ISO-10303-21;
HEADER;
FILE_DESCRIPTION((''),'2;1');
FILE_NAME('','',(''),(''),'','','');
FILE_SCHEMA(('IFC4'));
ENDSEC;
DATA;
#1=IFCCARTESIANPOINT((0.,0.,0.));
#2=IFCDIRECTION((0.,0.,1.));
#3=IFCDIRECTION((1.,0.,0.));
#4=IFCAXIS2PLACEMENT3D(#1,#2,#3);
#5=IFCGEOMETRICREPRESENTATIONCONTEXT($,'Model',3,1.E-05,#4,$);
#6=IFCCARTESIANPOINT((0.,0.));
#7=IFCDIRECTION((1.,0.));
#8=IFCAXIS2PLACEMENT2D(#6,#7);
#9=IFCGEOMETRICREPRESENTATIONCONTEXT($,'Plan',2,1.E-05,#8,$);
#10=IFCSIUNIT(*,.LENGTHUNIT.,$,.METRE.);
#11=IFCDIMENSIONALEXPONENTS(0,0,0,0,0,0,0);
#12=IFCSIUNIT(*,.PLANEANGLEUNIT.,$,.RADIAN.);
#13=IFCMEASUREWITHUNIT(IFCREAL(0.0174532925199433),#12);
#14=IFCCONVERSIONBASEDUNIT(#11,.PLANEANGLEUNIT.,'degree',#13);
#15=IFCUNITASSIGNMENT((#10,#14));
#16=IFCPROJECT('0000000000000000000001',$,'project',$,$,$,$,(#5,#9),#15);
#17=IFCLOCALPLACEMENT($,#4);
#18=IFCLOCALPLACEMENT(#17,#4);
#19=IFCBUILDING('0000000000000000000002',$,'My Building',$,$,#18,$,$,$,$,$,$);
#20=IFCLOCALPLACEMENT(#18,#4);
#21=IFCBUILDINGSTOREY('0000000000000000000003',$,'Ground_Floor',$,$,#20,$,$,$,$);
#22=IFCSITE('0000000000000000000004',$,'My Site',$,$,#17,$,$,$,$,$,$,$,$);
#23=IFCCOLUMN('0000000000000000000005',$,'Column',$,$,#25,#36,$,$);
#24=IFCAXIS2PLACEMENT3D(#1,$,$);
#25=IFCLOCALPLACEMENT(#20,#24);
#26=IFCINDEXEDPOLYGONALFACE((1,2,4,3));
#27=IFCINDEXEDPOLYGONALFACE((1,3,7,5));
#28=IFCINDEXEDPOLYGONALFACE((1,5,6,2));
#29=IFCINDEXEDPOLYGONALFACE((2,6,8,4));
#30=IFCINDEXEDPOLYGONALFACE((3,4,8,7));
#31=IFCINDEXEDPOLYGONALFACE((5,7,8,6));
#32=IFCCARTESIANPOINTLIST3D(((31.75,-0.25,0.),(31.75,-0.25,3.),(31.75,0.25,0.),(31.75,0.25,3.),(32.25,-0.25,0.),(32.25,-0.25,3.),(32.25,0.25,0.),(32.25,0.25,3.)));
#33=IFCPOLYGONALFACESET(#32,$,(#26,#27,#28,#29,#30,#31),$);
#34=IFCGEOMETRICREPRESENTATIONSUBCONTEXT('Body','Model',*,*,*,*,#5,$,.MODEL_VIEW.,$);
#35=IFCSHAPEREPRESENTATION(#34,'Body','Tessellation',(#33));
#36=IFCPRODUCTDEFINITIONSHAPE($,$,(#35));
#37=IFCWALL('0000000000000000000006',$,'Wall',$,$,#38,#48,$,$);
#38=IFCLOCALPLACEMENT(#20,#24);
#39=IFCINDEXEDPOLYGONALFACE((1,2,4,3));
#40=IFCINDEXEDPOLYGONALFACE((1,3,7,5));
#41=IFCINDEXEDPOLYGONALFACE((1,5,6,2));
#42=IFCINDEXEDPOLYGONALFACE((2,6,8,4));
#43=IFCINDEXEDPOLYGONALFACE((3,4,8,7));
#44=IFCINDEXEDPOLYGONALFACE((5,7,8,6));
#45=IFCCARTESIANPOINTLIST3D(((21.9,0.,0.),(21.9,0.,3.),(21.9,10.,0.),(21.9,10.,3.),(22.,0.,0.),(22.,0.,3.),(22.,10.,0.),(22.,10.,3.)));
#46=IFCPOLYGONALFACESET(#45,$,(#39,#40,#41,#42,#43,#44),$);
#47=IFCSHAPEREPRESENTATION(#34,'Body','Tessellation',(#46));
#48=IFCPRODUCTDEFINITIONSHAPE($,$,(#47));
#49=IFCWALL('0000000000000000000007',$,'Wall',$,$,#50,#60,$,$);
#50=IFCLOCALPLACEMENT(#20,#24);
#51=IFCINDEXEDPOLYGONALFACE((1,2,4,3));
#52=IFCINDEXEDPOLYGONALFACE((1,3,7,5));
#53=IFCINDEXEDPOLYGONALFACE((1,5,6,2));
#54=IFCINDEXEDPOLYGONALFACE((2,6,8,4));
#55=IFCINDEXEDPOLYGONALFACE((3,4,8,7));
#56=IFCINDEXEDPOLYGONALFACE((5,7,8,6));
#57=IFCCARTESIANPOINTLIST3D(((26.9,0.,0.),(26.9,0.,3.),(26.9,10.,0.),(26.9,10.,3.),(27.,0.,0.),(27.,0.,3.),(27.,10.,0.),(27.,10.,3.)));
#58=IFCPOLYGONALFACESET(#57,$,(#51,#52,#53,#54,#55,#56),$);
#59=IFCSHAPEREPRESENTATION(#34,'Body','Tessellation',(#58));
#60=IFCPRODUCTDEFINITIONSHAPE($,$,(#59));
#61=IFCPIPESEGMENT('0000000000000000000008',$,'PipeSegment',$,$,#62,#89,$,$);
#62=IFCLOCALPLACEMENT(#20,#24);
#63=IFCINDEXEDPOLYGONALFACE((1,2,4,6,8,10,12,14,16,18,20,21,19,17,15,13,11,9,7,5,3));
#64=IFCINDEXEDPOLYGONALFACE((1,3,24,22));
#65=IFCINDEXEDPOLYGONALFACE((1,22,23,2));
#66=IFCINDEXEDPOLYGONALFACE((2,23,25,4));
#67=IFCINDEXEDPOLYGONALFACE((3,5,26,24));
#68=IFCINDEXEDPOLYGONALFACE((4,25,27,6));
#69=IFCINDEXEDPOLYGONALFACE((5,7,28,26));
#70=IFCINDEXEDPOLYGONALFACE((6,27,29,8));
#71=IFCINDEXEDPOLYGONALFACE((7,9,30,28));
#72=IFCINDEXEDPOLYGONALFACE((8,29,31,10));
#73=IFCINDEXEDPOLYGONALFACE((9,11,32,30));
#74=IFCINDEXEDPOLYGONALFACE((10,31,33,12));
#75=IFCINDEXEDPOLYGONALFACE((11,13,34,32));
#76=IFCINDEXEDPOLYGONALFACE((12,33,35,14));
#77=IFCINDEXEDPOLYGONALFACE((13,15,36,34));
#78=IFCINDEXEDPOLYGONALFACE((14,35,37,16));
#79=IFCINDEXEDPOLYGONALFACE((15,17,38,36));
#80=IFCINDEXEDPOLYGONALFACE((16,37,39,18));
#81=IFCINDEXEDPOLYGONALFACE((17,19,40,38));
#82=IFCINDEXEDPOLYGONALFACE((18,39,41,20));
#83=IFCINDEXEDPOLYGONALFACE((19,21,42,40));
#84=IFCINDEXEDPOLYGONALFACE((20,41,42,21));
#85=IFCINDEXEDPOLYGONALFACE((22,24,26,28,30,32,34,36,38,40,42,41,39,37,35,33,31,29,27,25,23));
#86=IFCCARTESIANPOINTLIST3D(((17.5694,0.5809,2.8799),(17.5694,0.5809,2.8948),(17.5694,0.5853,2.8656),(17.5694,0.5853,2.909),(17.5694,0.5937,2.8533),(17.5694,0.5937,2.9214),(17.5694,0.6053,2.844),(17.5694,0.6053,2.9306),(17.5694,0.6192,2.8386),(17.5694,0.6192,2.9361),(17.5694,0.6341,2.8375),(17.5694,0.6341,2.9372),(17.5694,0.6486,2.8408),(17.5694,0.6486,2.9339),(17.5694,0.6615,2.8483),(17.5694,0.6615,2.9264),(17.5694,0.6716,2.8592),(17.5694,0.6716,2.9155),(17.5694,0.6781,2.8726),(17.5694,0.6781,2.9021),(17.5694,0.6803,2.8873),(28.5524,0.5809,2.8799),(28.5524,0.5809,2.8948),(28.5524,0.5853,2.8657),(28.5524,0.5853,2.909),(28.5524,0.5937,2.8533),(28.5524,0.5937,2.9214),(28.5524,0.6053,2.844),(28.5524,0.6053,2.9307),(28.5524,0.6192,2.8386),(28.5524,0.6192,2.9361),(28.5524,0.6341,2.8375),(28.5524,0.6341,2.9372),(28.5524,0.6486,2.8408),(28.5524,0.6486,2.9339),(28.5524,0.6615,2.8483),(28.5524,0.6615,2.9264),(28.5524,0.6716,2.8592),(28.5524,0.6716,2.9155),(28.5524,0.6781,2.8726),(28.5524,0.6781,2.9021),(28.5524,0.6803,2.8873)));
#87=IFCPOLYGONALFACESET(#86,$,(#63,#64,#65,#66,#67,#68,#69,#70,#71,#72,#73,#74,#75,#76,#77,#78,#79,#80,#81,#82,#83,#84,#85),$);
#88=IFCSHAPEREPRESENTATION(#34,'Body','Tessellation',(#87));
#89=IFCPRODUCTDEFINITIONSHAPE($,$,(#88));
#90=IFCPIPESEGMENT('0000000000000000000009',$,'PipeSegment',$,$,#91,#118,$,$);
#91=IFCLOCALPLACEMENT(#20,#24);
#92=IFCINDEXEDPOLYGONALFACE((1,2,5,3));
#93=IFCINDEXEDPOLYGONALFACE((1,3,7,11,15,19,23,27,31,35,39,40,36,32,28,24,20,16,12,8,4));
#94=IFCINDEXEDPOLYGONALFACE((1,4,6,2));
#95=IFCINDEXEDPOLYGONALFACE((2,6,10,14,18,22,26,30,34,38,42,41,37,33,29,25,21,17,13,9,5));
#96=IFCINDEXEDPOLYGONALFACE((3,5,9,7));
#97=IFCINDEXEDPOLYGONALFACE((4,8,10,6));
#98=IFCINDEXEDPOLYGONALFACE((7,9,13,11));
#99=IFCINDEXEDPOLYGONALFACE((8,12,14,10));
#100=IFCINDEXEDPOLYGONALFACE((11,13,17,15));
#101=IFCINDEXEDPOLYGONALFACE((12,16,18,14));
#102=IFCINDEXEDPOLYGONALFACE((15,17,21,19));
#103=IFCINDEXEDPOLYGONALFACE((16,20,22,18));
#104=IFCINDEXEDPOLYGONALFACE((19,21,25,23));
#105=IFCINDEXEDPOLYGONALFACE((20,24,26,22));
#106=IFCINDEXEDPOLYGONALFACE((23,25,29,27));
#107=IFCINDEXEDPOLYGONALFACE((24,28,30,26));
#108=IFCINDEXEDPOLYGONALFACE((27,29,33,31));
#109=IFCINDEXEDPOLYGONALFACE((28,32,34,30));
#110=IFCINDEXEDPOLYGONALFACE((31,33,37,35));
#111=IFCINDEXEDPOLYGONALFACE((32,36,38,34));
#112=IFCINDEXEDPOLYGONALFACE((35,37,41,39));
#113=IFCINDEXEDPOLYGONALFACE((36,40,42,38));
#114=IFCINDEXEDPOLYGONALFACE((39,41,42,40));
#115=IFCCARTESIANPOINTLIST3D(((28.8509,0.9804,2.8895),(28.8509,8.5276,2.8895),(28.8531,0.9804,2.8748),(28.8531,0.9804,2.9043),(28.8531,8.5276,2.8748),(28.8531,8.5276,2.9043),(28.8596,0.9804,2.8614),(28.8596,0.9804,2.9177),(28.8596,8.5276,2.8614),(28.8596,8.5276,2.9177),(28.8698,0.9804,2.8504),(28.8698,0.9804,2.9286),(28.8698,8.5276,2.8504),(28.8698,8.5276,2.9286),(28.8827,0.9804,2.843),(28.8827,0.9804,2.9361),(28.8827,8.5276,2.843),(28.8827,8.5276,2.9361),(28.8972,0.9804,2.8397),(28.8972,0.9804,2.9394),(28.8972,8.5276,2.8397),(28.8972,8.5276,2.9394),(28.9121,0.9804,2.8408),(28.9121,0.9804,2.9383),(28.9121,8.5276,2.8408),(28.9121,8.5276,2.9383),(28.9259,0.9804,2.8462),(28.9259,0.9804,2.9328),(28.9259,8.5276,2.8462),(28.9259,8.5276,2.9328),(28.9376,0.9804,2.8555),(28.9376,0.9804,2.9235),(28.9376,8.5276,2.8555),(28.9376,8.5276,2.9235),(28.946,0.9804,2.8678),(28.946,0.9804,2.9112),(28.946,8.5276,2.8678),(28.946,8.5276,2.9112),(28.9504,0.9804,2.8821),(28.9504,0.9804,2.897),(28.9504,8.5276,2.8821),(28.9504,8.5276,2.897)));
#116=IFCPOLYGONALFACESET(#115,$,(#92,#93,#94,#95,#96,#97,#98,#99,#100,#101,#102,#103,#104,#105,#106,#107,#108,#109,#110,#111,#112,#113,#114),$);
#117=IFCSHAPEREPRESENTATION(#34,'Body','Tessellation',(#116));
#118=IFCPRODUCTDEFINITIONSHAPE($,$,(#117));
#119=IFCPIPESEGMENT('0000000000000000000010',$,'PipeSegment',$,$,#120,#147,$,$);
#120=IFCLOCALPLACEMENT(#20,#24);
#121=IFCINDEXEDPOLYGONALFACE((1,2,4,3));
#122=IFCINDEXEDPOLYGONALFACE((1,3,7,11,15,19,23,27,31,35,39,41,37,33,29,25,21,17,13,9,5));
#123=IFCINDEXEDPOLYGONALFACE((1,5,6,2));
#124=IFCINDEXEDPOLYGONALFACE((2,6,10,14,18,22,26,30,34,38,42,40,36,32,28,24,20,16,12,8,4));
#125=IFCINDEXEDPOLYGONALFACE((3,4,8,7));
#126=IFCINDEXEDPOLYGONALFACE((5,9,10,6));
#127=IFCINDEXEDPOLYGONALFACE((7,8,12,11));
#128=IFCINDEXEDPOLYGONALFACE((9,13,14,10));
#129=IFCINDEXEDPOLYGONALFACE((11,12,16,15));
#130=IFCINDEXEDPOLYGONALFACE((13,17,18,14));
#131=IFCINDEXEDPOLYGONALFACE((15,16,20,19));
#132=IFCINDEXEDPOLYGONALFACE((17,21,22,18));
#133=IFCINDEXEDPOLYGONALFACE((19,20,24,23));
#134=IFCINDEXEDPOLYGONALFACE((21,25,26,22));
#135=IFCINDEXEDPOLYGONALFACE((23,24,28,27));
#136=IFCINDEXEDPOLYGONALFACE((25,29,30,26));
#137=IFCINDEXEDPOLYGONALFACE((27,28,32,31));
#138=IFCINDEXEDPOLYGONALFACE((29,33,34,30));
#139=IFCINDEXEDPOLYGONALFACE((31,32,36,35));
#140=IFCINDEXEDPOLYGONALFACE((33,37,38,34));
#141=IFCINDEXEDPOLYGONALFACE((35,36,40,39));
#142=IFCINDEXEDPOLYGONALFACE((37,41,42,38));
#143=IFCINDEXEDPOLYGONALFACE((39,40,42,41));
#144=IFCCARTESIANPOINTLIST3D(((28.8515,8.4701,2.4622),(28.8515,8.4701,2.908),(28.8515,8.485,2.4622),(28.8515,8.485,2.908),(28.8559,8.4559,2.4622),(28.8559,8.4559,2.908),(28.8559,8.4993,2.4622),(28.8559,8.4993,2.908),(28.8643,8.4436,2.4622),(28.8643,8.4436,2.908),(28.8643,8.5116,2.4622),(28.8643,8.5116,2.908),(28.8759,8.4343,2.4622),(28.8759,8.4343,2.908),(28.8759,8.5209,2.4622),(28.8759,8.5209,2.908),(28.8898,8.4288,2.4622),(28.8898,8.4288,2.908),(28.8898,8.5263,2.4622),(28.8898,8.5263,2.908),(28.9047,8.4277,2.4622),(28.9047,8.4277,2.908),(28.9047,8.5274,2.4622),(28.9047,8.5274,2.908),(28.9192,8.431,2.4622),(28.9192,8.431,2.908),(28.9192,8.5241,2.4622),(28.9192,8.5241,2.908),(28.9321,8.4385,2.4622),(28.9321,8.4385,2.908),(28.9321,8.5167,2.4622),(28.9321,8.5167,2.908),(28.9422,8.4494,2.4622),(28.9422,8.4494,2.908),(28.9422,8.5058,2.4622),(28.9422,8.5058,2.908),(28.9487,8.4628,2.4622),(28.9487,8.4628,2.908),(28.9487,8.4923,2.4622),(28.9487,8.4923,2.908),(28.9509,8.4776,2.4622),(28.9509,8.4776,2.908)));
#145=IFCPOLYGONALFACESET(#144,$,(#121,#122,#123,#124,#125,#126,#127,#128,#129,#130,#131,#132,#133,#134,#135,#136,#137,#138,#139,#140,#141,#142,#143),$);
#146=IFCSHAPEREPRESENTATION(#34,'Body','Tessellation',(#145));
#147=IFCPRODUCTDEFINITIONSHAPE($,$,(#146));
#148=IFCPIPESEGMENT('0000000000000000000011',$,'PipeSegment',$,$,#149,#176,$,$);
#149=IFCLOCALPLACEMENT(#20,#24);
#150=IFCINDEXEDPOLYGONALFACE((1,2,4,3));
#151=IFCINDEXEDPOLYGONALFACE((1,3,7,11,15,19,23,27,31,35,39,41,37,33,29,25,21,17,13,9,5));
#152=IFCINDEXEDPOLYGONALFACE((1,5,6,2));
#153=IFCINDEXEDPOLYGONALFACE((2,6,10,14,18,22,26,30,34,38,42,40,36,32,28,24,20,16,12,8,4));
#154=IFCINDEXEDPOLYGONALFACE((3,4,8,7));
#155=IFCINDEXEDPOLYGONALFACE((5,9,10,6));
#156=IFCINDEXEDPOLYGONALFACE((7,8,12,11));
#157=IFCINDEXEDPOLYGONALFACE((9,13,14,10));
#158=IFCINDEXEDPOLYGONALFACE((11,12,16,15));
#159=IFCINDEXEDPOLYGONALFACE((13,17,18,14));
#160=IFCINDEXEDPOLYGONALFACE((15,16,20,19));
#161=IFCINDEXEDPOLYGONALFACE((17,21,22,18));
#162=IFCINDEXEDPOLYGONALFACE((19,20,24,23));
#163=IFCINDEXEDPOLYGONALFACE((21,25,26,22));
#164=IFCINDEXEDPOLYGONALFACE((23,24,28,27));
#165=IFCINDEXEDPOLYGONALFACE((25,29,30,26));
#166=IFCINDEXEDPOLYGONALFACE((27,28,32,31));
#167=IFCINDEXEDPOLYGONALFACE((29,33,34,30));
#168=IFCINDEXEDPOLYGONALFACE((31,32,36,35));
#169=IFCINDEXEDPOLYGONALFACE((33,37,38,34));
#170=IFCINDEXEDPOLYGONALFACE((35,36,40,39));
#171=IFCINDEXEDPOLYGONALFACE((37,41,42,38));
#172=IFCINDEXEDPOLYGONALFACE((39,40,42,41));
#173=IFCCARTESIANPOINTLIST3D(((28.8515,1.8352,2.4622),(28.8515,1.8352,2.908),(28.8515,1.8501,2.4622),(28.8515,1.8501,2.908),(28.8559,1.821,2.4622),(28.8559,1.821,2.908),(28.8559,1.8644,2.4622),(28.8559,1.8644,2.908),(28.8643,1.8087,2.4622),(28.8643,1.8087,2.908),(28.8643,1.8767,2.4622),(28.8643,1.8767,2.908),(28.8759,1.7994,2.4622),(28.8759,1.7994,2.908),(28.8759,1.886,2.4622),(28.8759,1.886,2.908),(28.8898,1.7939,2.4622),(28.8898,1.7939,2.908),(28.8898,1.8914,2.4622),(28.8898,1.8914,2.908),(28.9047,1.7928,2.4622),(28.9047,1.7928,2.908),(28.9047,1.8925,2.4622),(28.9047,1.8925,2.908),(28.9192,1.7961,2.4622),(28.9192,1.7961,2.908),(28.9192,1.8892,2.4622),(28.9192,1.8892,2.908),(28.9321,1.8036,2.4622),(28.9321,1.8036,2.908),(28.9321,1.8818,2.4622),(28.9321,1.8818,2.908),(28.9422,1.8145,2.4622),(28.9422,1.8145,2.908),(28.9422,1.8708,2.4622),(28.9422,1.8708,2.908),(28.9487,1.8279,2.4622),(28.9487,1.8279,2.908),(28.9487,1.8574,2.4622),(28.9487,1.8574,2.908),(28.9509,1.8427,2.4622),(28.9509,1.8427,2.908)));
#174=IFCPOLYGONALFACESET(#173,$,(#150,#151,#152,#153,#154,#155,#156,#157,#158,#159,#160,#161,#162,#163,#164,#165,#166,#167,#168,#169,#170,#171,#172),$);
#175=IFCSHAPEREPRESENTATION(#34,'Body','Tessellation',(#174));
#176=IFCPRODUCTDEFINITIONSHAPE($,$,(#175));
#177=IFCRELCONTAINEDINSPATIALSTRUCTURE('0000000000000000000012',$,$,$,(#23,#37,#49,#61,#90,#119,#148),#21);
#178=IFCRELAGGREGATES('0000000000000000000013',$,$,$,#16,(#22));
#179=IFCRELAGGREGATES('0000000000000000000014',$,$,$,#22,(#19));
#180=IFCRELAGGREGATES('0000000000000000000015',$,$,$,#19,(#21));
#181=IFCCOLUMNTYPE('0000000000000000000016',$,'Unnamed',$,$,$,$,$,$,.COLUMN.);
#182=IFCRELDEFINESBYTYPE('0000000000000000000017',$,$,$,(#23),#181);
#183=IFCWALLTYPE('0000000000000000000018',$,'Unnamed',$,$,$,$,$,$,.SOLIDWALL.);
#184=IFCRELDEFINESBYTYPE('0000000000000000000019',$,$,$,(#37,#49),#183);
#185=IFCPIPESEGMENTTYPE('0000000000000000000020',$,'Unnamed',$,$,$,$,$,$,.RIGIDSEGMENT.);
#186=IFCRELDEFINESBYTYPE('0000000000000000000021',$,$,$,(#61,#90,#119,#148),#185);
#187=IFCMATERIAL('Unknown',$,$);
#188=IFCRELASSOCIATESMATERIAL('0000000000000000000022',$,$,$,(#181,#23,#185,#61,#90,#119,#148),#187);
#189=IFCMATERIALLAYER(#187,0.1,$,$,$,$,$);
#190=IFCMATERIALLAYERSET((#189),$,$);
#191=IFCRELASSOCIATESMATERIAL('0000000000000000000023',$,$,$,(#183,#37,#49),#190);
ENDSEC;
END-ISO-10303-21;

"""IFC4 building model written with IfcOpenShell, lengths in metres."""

from ifc_helpers import new_model, entity, si_unit, converted_unit, frame, origin_with_axes, origin_2d_with_axis, place, context, subcontext, project, spatial, line, indexed_curve, rectangle, circle, outline, extrude, material, layer, layer_set, layer_usage, material_profile, profile_set, profile_usage, type_object, element, save


model = new_model("IFC4")

# Units and contexts
model_context = context("Model", 3, precision=1e-05, world=origin_with_axes())
plan_context = context("Plan", 2, precision=1e-05, world=origin_2d_with_axis())
body_context_1 = subcontext(model_context, "Body", "Model", "MODEL_VIEW")
ifc_project = project(units=[si_unit("LENGTHUNIT", "METRE"), converted_unit("PLANEANGLEUNIT", "degree", entity("IfcReal", 0.0174532925199433), si_unit("PLANEANGLEUNIT", "RADIAN"), dimensions=[0, 0, 0, 0, 0, 0, 0])], contexts=[model_context, plan_context])

# Site, building, storey
site_placement = place(None, origin_with_axes())
site = spatial("IfcSite", under=ifc_project, at=site_placement, Name="My Site")
building_placement = place(site_placement, origin_with_axes())
building = spatial("IfcBuilding", under=site, at=building_placement, Name="My Building")
storey_placement = place(building_placement, origin_with_axes())
storey = spatial("IfcBuildingStorey", under=building, at=storey_placement, Name="Ground_Floor")

# Column
ifc_material = material(Name="Unknown")
ifc_material_profile_1 = material_profile(ifc_material, rectangle(XDim=0.5, YDim=0.5))
ifc_profile_set_1 = profile_set([ifc_material_profile_1])
ifc_profile_usage_1 = profile_usage(ifc_profile_set_1, cardinal=5)
column_type = type_object("IfcColumnType", Name="Unnamed", PredefinedType="COLUMN", material=ifc_profile_set_1)
column_placement = place(storey_placement, frame((32.0, 0.0, 0.0), z_axis=(0.0, 0.0, 1.0), x_axis=(1.0, 0.0, 0.0)))
element("IfcColumn", 1, at=column_placement, inside=storey, type_object=column_type, material=ifc_profile_usage_1, Name="Column", context=body_context_1, shape_type="SweptSolid", body=[
    extrude(rectangle(XDim=0.5, YDim=0.5), origin_with_axes(), (0.0, 0.0, 1.0), 3.0),
])

# Walls
ifc_layer = layer(ifc_material, 0.1)
ifc_layer_set = layer_set([ifc_layer])
ifc_layer_usage_1 = layer_usage(ifc_layer_set, "AXIS2", "POSITIVE", 0.0)
wall_type = type_object("IfcWallType", Name="Unnamed", PredefinedType="SOLIDWALL", material=ifc_layer_set)
wall_1_placement = place(storey_placement, frame((22.0, 0.0, 0.0), z_axis=(0.0, 0.0, 1.0), x_axis=(0.0, 1.0, 0.0)))
element("IfcWall", 2, at=wall_1_placement, inside=storey, type_object=wall_type, material=ifc_layer_usage_1, Name="Wall", context=body_context_1, shape_type="SweptSolid", body=[
    extrude(outline(indexed_curve([(0.0, 0.0), (0.0, 0.1), (10.0, 0.1), (10.0, 0.0)], segments=[line(1, 2, 3, 4, 1)])), origin_with_axes(), (0.0, 0.0, 1.0), 3.0),
])
ifc_layer_usage_2 = layer_usage(ifc_layer_set, "AXIS2", "POSITIVE", 0.0)
wall_2_placement = place(storey_placement, frame((27.0, 0.0, 0.0), z_axis=(0.0, 0.0, 1.0), x_axis=(0.0, 1.0, 0.0)))
element("IfcWall", 3, at=wall_2_placement, inside=storey, type_object=wall_type, material=ifc_layer_usage_2, Name="Wall", context=body_context_1, shape_type="SweptSolid", body=[
    extrude(outline(indexed_curve([(0.0, 0.0), (0.0, 0.1), (10.0, 0.1), (10.0, 0.0)], segments=[line(1, 2, 3, 4, 1)])), origin_with_axes(), (0.0, 0.0, 1.0), 3.0),
])

# Pipe segments
ifc_material_profile_2 = material_profile(ifc_material, circle(Radius=0.05))
ifc_profile_set_2 = profile_set([ifc_material_profile_2])
ifc_profile_usage_2 = profile_usage(ifc_profile_set_2, cardinal=5)
pipe_segment_type = type_object("IfcPipeSegmentType", Name="Unnamed", PredefinedType="RIGIDSEGMENT", material=ifc_profile_set_2)
pipe_segment_1_placement = place(storey_placement, frame((17.5694, 0.6303, 2.8873), z_axis=(1.0, -0.000001, 0.000001), x_axis=(0.000001, 1.0, 0.0)))
element("IfcPipeSegment", 4, at=pipe_segment_1_placement, inside=storey, type_object=pipe_segment_type, material=ifc_profile_usage_2, Name="PipeSegment", context=body_context_1, shape_type="SweptSolid", body=[
    extrude(circle(Radius=0.05), origin_with_axes(), (0.0, 0.0, 1.0), 10.9829),
])
ifc_profile_usage_3 = profile_usage(ifc_profile_set_2, cardinal=5)
pipe_segment_2_placement = place(storey_placement, frame((28.9009, 0.9804, 2.8895), z_axis=(0.0, 1.0, 0.0), x_axis=(-1.0, 0.0, 0.0)))
element("IfcPipeSegment", 5, at=pipe_segment_2_placement, inside=storey, type_object=pipe_segment_type, material=ifc_profile_usage_3, Name="PipeSegment", context=body_context_1, shape_type="SweptSolid", body=[
    extrude(circle(Radius=0.05), origin_with_axes(), (0.0, 0.0, 1.0), 7.5472),
])
ifc_profile_usage_4 = profile_usage(ifc_profile_set_2, cardinal=5)
pipe_segment_3_placement = place(storey_placement, frame((28.9009, 8.4776, 2.908), z_axis=(0.0, 0.0, -1.0), x_axis=(1.0, 0.0, 0.0)))
element("IfcPipeSegment", 6, at=pipe_segment_3_placement, inside=storey, type_object=pipe_segment_type, material=ifc_profile_usage_4, Name="PipeSegment", context=body_context_1, shape_type="SweptSolid", body=[
    extrude(circle(Radius=0.05), origin_with_axes(), (0.0, 0.0, 1.0), 0.4458),
])
ifc_profile_usage_5 = profile_usage(ifc_profile_set_2, cardinal=5)
pipe_segment_4_placement = place(storey_placement, frame((28.9009, 1.8427, 2.908), z_axis=(0.0, 0.0, -1.0), x_axis=(1.0, 0.0, 0.0)))
element("IfcPipeSegment", 7, at=pipe_segment_4_placement, inside=storey, type_object=pipe_segment_type, material=ifc_profile_usage_5, Name="PipeSegment", context=body_context_1, shape_type="SweptSolid", body=[
    extrude(circle(Radius=0.05), origin_with_axes(), (0.0, 0.0, 1.0), 0.4458),
])

save(model, "model.ifc")
